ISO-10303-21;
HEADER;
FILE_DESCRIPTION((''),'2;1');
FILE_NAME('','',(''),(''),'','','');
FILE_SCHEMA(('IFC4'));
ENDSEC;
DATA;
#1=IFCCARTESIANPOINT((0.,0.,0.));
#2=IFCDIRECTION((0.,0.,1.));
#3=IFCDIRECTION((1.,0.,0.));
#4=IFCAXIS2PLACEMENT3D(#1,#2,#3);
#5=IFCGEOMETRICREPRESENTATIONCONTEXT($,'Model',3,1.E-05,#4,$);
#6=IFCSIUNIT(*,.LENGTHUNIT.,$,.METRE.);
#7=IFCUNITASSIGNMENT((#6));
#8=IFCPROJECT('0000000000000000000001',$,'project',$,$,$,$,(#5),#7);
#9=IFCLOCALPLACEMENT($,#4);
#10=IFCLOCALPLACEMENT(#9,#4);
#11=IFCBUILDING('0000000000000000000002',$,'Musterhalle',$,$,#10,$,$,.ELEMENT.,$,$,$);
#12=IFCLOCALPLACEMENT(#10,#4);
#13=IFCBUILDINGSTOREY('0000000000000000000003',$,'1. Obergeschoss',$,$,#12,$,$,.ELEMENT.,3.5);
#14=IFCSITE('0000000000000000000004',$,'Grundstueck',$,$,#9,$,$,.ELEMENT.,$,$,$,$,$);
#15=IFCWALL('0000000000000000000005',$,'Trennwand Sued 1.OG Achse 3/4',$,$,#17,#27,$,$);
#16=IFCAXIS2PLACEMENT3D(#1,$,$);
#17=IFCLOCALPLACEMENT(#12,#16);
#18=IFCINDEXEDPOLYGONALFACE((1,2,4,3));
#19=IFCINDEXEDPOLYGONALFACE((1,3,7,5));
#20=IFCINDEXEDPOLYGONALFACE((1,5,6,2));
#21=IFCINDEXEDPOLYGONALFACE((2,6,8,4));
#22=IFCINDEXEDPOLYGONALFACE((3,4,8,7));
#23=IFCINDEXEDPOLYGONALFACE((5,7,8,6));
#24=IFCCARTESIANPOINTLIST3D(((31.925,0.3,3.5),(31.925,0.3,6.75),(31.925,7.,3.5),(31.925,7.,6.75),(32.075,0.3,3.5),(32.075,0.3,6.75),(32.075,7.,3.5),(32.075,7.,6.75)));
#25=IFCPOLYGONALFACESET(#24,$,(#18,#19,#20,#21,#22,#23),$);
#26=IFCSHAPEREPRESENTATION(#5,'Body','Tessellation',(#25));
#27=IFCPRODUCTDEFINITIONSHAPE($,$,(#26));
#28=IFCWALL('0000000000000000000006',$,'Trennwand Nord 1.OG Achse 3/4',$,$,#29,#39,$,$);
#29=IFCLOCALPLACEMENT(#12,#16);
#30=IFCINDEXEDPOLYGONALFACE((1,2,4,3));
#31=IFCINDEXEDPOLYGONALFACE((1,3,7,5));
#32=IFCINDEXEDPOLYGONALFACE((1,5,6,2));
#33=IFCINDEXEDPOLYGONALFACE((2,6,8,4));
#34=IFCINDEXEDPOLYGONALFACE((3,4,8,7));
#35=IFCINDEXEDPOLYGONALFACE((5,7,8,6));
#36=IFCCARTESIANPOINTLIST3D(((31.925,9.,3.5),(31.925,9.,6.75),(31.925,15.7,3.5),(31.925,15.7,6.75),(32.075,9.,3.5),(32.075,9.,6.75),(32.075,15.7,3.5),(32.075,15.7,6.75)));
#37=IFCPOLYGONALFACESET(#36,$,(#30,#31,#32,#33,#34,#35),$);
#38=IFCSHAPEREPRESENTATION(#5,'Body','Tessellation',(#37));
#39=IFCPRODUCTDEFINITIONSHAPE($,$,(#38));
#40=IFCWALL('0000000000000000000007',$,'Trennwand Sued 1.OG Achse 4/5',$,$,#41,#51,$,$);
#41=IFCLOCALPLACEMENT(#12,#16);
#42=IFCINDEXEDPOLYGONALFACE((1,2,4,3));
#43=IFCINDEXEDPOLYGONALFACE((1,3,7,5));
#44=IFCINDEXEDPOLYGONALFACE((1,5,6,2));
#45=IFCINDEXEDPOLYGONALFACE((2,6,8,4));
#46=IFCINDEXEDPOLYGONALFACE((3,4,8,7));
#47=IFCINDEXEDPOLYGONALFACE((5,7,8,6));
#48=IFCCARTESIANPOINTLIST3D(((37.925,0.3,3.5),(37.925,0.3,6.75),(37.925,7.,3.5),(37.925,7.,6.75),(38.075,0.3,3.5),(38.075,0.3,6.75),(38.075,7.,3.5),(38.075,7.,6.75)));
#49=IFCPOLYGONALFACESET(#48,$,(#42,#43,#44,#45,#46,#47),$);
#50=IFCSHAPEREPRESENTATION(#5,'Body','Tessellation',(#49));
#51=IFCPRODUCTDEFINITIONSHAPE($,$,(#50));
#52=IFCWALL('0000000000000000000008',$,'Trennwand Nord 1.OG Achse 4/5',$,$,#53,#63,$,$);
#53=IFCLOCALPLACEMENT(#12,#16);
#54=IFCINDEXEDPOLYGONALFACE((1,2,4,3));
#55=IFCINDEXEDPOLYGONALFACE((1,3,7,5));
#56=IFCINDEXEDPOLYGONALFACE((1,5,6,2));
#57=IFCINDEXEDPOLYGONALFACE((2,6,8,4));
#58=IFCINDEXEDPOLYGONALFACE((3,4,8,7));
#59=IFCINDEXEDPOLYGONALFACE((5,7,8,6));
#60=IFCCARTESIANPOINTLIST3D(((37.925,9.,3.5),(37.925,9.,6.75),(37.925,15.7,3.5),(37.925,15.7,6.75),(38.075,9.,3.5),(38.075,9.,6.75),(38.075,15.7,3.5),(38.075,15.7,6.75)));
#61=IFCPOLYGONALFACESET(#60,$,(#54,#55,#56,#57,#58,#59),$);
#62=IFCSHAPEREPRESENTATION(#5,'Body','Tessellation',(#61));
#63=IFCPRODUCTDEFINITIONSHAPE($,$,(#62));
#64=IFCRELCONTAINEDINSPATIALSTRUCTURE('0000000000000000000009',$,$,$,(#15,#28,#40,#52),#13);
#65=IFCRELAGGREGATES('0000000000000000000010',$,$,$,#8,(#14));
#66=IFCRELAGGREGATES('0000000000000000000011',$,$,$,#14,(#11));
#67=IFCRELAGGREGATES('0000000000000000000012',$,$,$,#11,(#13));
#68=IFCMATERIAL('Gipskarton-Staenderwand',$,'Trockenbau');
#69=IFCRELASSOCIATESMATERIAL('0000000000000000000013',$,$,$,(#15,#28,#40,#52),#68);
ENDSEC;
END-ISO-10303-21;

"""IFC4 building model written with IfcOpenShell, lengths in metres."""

from ifc_helpers import new_model, si_unit, frame, origin_with_axes, origin_2d, place, context, project, spatial, rectangle, extrude, material, element, save


model = new_model("IFC4")

# Units and contexts
model_context = context("Model", 3, precision=1e-05, world=origin_with_axes())
ifc_project = project(units=[si_unit("LENGTHUNIT", "METRE")], contexts=[model_context])

# Site, building, storey
site_placement = place(None, origin_with_axes())
site = spatial("IfcSite", under=ifc_project, at=site_placement, Name="Grundstueck", CompositionType="ELEMENT")
building_placement = place(site_placement, origin_with_axes())
building = spatial("IfcBuilding", under=site, at=building_placement, Name="Musterhalle", CompositionType="ELEMENT")
storey_placement = place(building_placement, origin_with_axes())
storey = spatial("IfcBuildingStorey", under=building, at=storey_placement, Name="1. Obergeschoss", CompositionType="ELEMENT", Elevation=3.5)

# Walls
placement = place(storey_placement, origin_with_axes())
ifc_material_1 = material(Name="Gipskarton-Staenderwand", Category="Trockenbau")
element("IfcWall", 1, at=placement, inside=storey, material=ifc_material_1, Name="Trennwand Sued 1.OG Achse 3/4", context=model_context, shape_type="SweptSolid", body=[
    extrude(rectangle(XDim=0.15, YDim=6.7, at=origin_2d()), frame((32.0, 3.65, 3.5), z_axis=(0.0, 0.0, 1.0), x_axis=(1.0, 0.0, 0.0)), (0.0, 0.0, 1.0), 3.25),
])
element("IfcWall", 2, at=placement, inside=storey, material=ifc_material_1, Name="Trennwand Nord 1.OG Achse 3/4", context=model_context, shape_type="SweptSolid", body=[
    extrude(rectangle(XDim=0.15, YDim=6.7, at=origin_2d()), frame((32.0, 12.35, 3.5), z_axis=(0.0, 0.0, 1.0), x_axis=(1.0, 0.0, 0.0)), (0.0, 0.0, 1.0), 3.25),
])
element("IfcWall", 3, at=placement, inside=storey, material=ifc_material_1, Name="Trennwand Sued 1.OG Achse 4/5", context=model_context, shape_type="SweptSolid", body=[
    extrude(rectangle(XDim=0.15, YDim=6.7, at=origin_2d()), frame((38.0, 3.65, 3.5), z_axis=(0.0, 0.0, 1.0), x_axis=(1.0, 0.0, 0.0)), (0.0, 0.0, 1.0), 3.25),
])
element("IfcWall", 4, at=placement, inside=storey, material=ifc_material_1, Name="Trennwand Nord 1.OG Achse 4/5", context=model_context, shape_type="SweptSolid", body=[
    extrude(rectangle(XDim=0.15, YDim=6.7, at=origin_2d()), frame((38.0, 12.35, 3.5), z_axis=(0.0, 0.0, 1.0), x_axis=(1.0, 0.0, 0.0)), (0.0, 0.0, 1.0), 3.25),
])

save(model, "model.ifc")
